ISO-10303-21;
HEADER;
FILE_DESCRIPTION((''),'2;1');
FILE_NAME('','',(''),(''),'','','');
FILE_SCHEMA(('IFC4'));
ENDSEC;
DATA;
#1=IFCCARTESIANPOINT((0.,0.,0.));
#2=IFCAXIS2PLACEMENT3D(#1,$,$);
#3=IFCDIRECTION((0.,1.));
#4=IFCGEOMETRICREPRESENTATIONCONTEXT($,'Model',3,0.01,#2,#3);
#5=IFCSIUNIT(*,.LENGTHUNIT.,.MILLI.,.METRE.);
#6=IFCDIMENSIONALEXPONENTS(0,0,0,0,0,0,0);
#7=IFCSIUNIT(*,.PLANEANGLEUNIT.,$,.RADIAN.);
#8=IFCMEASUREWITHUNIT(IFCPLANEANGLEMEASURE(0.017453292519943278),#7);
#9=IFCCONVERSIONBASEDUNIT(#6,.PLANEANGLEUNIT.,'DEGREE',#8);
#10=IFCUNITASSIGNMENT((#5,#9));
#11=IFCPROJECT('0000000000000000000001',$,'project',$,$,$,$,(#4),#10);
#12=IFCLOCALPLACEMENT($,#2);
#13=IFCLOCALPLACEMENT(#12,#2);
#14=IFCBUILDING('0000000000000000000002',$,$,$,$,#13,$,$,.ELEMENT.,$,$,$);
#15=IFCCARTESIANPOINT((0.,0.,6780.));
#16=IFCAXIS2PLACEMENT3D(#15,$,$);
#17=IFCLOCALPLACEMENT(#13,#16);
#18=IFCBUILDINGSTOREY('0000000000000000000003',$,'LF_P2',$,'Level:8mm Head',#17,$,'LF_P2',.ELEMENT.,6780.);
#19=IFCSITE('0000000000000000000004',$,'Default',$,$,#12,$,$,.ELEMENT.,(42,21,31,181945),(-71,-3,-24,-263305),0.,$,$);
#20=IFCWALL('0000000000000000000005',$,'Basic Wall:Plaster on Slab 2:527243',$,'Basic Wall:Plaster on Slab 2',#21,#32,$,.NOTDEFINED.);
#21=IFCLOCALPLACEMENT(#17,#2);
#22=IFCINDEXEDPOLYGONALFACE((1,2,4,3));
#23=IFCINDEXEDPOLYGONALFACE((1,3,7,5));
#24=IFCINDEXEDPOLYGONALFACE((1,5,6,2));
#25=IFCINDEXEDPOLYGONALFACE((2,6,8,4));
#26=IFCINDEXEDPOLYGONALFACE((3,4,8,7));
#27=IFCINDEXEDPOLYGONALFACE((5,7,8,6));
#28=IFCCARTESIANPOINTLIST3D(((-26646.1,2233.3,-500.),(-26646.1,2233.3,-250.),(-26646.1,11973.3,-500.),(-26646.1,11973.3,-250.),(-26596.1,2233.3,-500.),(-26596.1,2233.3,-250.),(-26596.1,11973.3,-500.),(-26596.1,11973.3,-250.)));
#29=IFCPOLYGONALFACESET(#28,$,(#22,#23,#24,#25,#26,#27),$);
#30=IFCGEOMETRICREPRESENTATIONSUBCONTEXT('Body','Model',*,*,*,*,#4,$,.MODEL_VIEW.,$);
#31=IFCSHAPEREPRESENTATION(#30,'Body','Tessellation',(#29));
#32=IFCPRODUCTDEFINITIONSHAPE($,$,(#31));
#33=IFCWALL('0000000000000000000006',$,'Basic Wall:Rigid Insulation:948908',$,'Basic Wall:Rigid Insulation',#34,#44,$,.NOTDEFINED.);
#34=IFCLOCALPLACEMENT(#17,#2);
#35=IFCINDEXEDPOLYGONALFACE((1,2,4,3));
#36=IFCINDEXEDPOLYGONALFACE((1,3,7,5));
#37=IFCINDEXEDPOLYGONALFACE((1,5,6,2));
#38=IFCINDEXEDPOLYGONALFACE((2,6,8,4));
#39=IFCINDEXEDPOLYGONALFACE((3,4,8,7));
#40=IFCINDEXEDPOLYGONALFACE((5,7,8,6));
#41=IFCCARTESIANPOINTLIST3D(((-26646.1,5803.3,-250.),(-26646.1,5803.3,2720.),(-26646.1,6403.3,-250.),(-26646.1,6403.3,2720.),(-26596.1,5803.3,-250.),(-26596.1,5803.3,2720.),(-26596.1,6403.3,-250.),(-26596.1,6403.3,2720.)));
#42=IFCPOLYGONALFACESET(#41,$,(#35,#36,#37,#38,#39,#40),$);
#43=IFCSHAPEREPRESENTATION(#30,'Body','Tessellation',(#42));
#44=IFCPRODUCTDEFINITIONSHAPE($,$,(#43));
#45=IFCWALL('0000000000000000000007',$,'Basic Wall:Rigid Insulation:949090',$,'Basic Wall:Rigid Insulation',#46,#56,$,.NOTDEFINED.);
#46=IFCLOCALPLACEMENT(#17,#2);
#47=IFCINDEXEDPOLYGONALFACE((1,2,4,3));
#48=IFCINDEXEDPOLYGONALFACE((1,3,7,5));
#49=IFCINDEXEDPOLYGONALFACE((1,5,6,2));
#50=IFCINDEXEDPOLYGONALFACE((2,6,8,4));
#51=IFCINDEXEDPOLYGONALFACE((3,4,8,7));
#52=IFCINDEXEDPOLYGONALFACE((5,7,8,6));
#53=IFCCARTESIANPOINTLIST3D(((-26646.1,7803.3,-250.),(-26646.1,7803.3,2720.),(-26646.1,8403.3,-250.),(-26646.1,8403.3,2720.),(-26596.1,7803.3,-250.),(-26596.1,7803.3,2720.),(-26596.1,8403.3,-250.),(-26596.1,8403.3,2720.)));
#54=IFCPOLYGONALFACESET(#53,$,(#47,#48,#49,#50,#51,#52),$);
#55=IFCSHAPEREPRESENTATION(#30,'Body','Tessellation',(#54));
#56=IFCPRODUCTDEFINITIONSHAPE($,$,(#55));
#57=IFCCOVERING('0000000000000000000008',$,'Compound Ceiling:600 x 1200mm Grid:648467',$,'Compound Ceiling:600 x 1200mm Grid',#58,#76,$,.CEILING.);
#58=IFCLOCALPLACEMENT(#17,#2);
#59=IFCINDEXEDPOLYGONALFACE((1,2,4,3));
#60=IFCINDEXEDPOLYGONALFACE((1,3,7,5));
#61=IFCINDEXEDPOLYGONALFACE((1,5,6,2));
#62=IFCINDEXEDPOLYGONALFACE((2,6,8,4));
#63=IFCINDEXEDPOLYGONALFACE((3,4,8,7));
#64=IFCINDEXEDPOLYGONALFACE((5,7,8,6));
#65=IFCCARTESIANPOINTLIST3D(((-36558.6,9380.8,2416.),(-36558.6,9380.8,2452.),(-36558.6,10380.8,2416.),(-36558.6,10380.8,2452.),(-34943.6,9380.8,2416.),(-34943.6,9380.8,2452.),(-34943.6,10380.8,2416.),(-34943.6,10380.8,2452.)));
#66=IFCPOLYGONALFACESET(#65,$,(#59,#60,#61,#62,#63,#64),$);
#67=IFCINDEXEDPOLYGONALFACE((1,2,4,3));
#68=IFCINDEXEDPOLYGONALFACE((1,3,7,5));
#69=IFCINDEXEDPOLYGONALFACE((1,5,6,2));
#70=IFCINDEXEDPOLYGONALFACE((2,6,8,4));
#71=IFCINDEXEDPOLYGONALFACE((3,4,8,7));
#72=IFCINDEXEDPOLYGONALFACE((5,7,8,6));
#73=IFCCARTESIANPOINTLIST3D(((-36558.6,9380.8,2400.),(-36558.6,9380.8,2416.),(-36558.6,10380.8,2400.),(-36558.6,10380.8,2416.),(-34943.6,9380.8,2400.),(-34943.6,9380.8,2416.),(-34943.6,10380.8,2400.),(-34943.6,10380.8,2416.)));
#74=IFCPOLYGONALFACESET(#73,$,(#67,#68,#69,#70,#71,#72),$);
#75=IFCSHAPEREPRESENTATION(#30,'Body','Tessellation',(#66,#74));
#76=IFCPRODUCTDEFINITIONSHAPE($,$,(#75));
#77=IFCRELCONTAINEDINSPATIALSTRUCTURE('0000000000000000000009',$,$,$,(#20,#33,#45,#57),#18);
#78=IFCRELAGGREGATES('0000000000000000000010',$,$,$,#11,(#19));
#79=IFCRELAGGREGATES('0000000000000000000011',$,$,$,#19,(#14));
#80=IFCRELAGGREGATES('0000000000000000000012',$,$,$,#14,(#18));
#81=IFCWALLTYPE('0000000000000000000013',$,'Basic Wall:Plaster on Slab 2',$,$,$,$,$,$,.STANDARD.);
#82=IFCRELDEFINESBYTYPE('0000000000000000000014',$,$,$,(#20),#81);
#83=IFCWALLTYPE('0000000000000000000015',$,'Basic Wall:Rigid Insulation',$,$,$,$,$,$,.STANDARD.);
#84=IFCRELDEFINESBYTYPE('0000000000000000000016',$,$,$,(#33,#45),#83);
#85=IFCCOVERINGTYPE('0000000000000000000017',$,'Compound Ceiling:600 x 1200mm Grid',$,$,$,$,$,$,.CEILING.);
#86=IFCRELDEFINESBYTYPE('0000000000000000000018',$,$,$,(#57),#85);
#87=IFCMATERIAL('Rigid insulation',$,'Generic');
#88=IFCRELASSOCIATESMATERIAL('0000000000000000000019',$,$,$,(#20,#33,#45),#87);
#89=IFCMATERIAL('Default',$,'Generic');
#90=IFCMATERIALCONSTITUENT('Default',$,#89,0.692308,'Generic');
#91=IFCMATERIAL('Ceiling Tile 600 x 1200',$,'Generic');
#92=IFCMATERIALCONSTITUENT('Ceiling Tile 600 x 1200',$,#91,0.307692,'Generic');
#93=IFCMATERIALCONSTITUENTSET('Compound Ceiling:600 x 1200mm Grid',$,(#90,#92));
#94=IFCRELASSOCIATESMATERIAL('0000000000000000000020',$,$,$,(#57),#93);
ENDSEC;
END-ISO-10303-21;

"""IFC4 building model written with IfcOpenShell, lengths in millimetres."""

from ifc_helpers import new_model, entity, si_unit, converted_unit, direction, frame, origin, place, context, subcontext, project, spatial, indexed_curve, outline, extrude, material, constituent, constituent_set, type_object, element, save


model = new_model("IFC4")

# Units and contexts
model_context = context("Model", 3, precision=0.01, world=origin(), true_north=direction((0.0, 1.0)))
body_context = subcontext(model_context, "Body", "Model", "MODEL_VIEW")
ifc_project = project(units=[si_unit("LENGTHUNIT", "METRE", prefix="MILLI"), converted_unit("PLANEANGLEUNIT", "DEGREE", entity("IfcPlaneAngleMeasure", 0.017453292519943278), si_unit("PLANEANGLEUNIT", "RADIAN"), dimensions=[0, 0, 0, 0, 0, 0, 0])], contexts=[model_context])

# Site, building, storey
site_placement = place(None, origin())
site = spatial("IfcSite", under=ifc_project, at=site_placement, Name="Default", CompositionType="ELEMENT", RefLatitude=(42, 21, 31, 181945), RefLongitude=(-71, -3, -24, -263305), RefElevation=0.0)
building_placement = place(site_placement, origin())
building = spatial("IfcBuilding", under=site, at=building_placement, CompositionType="ELEMENT")
storey_placement = place(building_placement, frame((0.0, 0.0, 6780.0)))
storey = spatial("IfcBuildingStorey", under=building, at=storey_placement, Name="LF_P2", ObjectType="Level:8mm Head", LongName="LF_P2", CompositionType="ELEMENT", Elevation=6780.0)

# Shared definitions
ifc_material_1 = material(Name="Rigid insulation", Category="Generic")

# Walls
wall_type_1 = type_object("IfcWallType", Name="Basic Wall:Plaster on Slab 2", PredefinedType="STANDARD")
wall_1_placement = place(storey_placement, frame((-26621.1, 2233.3, -500.0), z_axis=(0.0, 0.0, 1.0), x_axis=(0.0, 1.0, 0.0)))
element("IfcWall", 1, at=wall_1_placement, inside=storey, type_object=wall_type_1, material=ifc_material_1, Name="Basic Wall:Plaster on Slab 2:527243", ObjectType="Basic Wall:Plaster on Slab 2", PredefinedType="NOTDEFINED", context=body_context, shape_type="SweptSolid", body=[
    extrude(outline(indexed_curve([(9740.0, 25.0), (0.0, 25.0), (0.0, -25.0), (9740.0, -25.0), (9740.0, 25.0)], self_intersect=False)), origin(), (0.0, 0.0, 1.0), 250.0),
])
wall_type_2 = type_object("IfcWallType", Name="Basic Wall:Rigid Insulation", PredefinedType="STANDARD")
wall_2_placement = place(storey_placement, frame((-26621.1, 6403.3, -250.0), z_axis=(0.0, 0.0, 1.0), x_axis=(0.0, -1.0, 0.0)))
element("IfcWall", 2, at=wall_2_placement, inside=storey, type_object=wall_type_2, material=ifc_material_1, Name="Basic Wall:Rigid Insulation:948908", ObjectType="Basic Wall:Rigid Insulation", PredefinedType="NOTDEFINED", context=body_context, shape_type="SweptSolid", body=[
    extrude(outline(indexed_curve([(600.0, 25.0), (0.0, 25.0), (0.0, -25.0), (600.0, -25.0), (600.0, 25.0)], self_intersect=False)), origin(), (0.0, 0.0, 1.0), 2970.0),
])
wall_3_placement = place(storey_placement, frame((-26621.1, 8403.3, -250.0), z_axis=(0.0, 0.0, 1.0), x_axis=(0.0, -1.0, 0.0)))
element("IfcWall", 3, at=wall_3_placement, inside=storey, type_object=wall_type_2, material=ifc_material_1, Name="Basic Wall:Rigid Insulation:949090", ObjectType="Basic Wall:Rigid Insulation", PredefinedType="NOTDEFINED", context=body_context, shape_type="SweptSolid", body=[
    extrude(outline(indexed_curve([(600.0, 25.0), (0.0, 25.0), (0.0, -25.0), (600.0, -25.0), (600.0, 25.0)], self_intersect=False)), origin(), (0.0, 0.0, 1.0), 2970.0),
])

# Covering
ifc_material_2 = material(Name="Default", Category="Generic")
ifc_constituent_1 = constituent(ifc_material_2, Name="Default", Category="Generic", fraction=0.692308)
ifc_material_3 = material(Name="Ceiling Tile 600 x 1200", Category="Generic")
ifc_constituent_2 = constituent(ifc_material_3, Name="Ceiling Tile 600 x 1200", Category="Generic", fraction=0.307692)
ifc_constituent_set = constituent_set(constituents=[ifc_constituent_1, ifc_constituent_2], Name="Compound Ceiling:600 x 1200mm Grid")
covering_type = type_object("IfcCoveringType", Name="Compound Ceiling:600 x 1200mm Grid", PredefinedType="CEILING")
covering_1_placement = place(storey_placement, origin())
element("IfcCovering", 4, at=covering_1_placement, inside=storey, type_object=covering_type, material=ifc_constituent_set, Name="Compound Ceiling:600 x 1200mm Grid:648467", ObjectType="Compound Ceiling:600 x 1200mm Grid", PredefinedType="CEILING", context=body_context, shape_type="SweptSolid", body=[
    extrude(outline(indexed_curve([(-500.0, -807.5), (500.0, -807.5), (500.0, 807.5), (-500.0, 807.5), (-500.0, -807.5)], self_intersect=False)), frame((-35751.1, 9880.8, 2416.0), z_axis=(0.0, 0.0, 1.0), x_axis=(0.0, 1.0, 0.0)), (0.0, 0.0, 1.0), 36.0),
    extrude(outline(indexed_curve([(-807.5, -500.0), (807.5, -500.0), (807.5, 500.0), (-807.5, 500.0), (-807.5, -500.0)], self_intersect=False)), frame((-35751.1, 9880.8, 2400.0)), (0.0, 0.0, 1.0), 16.0),
])

save(model, "model.ifc")
